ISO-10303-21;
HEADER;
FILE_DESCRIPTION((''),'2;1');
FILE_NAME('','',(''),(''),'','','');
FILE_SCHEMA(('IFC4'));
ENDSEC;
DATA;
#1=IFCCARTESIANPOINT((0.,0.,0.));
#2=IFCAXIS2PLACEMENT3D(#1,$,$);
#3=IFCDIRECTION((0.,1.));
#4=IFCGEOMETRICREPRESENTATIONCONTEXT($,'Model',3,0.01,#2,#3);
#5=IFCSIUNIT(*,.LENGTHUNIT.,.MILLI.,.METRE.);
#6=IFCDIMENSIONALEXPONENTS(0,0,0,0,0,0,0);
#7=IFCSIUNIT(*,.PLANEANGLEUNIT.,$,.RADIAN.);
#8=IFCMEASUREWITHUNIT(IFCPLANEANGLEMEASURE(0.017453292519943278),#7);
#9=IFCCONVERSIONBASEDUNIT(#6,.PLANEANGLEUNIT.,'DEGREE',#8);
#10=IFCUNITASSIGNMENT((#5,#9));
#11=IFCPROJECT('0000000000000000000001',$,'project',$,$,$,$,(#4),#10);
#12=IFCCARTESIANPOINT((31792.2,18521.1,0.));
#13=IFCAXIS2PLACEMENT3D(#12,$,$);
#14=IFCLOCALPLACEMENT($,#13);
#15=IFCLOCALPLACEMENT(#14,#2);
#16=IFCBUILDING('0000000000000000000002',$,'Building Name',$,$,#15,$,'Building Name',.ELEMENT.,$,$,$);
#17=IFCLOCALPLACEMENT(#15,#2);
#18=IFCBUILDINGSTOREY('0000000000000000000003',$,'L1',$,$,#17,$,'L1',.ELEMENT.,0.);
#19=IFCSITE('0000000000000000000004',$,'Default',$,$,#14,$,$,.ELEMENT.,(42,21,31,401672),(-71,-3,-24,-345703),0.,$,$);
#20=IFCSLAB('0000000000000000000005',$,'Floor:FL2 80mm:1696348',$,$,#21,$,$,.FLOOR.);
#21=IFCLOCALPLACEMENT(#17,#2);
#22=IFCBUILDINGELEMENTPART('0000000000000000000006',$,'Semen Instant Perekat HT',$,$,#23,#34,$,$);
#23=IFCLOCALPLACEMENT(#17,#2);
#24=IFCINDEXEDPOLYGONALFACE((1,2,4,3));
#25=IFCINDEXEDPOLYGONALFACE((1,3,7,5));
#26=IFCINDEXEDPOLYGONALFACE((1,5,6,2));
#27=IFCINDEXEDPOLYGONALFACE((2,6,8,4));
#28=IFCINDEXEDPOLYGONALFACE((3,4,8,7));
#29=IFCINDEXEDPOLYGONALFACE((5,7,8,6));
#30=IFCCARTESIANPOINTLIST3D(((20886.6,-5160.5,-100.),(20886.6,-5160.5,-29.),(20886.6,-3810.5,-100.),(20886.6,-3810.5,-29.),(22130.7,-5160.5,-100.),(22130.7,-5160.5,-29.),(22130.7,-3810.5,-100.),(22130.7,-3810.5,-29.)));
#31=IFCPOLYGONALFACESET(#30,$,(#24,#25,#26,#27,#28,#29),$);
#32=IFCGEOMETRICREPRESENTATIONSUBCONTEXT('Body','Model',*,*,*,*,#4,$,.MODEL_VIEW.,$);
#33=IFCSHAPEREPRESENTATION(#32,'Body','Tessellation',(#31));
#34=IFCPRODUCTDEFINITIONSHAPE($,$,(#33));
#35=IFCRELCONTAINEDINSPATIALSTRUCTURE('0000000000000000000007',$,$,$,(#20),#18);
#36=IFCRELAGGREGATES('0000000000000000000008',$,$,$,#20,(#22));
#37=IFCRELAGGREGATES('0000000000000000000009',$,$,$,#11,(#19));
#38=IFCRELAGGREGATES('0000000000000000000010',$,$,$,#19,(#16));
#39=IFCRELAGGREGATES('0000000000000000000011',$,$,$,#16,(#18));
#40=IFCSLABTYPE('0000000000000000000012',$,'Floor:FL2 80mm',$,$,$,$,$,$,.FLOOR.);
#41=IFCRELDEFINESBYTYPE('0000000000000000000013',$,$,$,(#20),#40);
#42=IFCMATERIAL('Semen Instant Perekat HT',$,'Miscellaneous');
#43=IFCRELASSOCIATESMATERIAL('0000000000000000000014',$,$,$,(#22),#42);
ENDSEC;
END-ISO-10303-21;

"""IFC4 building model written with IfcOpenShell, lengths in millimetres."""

from ifc_helpers import new_model, entity, si_unit, converted_unit, direction, frame, origin, place, context, subcontext, project, spatial, indexed_curve, outline, extrude, material, type_object, element, aggregate, save


model = new_model("IFC4")

# Units and contexts
model_context = context("Model", 3, precision=0.01, world=origin(), true_north=direction((0.0, 1.0)))
body_context = subcontext(model_context, "Body", "Model", "MODEL_VIEW")
ifc_project = project(units=[si_unit("LENGTHUNIT", "METRE", prefix="MILLI"), converted_unit("PLANEANGLEUNIT", "DEGREE", entity("IfcPlaneAngleMeasure", 0.017453292519943278), si_unit("PLANEANGLEUNIT", "RADIAN"), dimensions=[0, 0, 0, 0, 0, 0, 0])], contexts=[model_context])

# Site, building, storey
site_placement = place(None, frame((31792.2, 18521.1, 0.0)))
site = spatial("IfcSite", under=ifc_project, at=site_placement, Name="Default", CompositionType="ELEMENT", RefLatitude=(42, 21, 31, 401672), RefLongitude=(-71, -3, -24, -345703), RefElevation=0.0)
building_placement = place(site_placement, origin())
building = spatial("IfcBuilding", under=site, at=building_placement, Name="Building Name", LongName="Building Name", CompositionType="ELEMENT")
storey_placement = place(building_placement, origin())
storey = spatial("IfcBuildingStorey", under=building, at=storey_placement, Name="L1", LongName="L1", CompositionType="ELEMENT", Elevation=0.0)

# Shared definitions
ifc_material_1 = material(Name="Semen Instant Perekat HT", Category="Miscellaneous")

# Slab, building element part
slab_type_1 = type_object("IfcSlabType", Name="Floor:FL2 80mm", PredefinedType="FLOOR")
slab_1_placement = place(storey_placement, origin())
slab_1 = element("IfcSlab", 1, at=slab_1_placement, inside=storey, type_object=slab_type_1, Name="Floor:FL2 80mm:1696348", PredefinedType="FLOOR")
building_element_part_1_placement = place(slab_1_placement, origin())
building_element_part_1 = element("IfcBuildingElementPart", 2, at=building_element_part_1_placement, material=ifc_material_1, Name="Semen Instant Perekat HT", context=body_context, shape_type="SweptSolid", body=[
    extrude(outline(indexed_curve([(-675.0, -622.0), (675.0, -622.0), (675.0, 622.0), (-675.0, 622.0), (-675.0, -622.0)], self_intersect=False)), frame((21508.7, -4485.5, -100.0), z_axis=(0.0, 0.0, 1.0), x_axis=(0.0, -1.0, 0.0)), (0.0, 0.0, 1.0), 71.0),
])
aggregate(slab_1, [building_element_part_1])

save(model, "model.ifc")
